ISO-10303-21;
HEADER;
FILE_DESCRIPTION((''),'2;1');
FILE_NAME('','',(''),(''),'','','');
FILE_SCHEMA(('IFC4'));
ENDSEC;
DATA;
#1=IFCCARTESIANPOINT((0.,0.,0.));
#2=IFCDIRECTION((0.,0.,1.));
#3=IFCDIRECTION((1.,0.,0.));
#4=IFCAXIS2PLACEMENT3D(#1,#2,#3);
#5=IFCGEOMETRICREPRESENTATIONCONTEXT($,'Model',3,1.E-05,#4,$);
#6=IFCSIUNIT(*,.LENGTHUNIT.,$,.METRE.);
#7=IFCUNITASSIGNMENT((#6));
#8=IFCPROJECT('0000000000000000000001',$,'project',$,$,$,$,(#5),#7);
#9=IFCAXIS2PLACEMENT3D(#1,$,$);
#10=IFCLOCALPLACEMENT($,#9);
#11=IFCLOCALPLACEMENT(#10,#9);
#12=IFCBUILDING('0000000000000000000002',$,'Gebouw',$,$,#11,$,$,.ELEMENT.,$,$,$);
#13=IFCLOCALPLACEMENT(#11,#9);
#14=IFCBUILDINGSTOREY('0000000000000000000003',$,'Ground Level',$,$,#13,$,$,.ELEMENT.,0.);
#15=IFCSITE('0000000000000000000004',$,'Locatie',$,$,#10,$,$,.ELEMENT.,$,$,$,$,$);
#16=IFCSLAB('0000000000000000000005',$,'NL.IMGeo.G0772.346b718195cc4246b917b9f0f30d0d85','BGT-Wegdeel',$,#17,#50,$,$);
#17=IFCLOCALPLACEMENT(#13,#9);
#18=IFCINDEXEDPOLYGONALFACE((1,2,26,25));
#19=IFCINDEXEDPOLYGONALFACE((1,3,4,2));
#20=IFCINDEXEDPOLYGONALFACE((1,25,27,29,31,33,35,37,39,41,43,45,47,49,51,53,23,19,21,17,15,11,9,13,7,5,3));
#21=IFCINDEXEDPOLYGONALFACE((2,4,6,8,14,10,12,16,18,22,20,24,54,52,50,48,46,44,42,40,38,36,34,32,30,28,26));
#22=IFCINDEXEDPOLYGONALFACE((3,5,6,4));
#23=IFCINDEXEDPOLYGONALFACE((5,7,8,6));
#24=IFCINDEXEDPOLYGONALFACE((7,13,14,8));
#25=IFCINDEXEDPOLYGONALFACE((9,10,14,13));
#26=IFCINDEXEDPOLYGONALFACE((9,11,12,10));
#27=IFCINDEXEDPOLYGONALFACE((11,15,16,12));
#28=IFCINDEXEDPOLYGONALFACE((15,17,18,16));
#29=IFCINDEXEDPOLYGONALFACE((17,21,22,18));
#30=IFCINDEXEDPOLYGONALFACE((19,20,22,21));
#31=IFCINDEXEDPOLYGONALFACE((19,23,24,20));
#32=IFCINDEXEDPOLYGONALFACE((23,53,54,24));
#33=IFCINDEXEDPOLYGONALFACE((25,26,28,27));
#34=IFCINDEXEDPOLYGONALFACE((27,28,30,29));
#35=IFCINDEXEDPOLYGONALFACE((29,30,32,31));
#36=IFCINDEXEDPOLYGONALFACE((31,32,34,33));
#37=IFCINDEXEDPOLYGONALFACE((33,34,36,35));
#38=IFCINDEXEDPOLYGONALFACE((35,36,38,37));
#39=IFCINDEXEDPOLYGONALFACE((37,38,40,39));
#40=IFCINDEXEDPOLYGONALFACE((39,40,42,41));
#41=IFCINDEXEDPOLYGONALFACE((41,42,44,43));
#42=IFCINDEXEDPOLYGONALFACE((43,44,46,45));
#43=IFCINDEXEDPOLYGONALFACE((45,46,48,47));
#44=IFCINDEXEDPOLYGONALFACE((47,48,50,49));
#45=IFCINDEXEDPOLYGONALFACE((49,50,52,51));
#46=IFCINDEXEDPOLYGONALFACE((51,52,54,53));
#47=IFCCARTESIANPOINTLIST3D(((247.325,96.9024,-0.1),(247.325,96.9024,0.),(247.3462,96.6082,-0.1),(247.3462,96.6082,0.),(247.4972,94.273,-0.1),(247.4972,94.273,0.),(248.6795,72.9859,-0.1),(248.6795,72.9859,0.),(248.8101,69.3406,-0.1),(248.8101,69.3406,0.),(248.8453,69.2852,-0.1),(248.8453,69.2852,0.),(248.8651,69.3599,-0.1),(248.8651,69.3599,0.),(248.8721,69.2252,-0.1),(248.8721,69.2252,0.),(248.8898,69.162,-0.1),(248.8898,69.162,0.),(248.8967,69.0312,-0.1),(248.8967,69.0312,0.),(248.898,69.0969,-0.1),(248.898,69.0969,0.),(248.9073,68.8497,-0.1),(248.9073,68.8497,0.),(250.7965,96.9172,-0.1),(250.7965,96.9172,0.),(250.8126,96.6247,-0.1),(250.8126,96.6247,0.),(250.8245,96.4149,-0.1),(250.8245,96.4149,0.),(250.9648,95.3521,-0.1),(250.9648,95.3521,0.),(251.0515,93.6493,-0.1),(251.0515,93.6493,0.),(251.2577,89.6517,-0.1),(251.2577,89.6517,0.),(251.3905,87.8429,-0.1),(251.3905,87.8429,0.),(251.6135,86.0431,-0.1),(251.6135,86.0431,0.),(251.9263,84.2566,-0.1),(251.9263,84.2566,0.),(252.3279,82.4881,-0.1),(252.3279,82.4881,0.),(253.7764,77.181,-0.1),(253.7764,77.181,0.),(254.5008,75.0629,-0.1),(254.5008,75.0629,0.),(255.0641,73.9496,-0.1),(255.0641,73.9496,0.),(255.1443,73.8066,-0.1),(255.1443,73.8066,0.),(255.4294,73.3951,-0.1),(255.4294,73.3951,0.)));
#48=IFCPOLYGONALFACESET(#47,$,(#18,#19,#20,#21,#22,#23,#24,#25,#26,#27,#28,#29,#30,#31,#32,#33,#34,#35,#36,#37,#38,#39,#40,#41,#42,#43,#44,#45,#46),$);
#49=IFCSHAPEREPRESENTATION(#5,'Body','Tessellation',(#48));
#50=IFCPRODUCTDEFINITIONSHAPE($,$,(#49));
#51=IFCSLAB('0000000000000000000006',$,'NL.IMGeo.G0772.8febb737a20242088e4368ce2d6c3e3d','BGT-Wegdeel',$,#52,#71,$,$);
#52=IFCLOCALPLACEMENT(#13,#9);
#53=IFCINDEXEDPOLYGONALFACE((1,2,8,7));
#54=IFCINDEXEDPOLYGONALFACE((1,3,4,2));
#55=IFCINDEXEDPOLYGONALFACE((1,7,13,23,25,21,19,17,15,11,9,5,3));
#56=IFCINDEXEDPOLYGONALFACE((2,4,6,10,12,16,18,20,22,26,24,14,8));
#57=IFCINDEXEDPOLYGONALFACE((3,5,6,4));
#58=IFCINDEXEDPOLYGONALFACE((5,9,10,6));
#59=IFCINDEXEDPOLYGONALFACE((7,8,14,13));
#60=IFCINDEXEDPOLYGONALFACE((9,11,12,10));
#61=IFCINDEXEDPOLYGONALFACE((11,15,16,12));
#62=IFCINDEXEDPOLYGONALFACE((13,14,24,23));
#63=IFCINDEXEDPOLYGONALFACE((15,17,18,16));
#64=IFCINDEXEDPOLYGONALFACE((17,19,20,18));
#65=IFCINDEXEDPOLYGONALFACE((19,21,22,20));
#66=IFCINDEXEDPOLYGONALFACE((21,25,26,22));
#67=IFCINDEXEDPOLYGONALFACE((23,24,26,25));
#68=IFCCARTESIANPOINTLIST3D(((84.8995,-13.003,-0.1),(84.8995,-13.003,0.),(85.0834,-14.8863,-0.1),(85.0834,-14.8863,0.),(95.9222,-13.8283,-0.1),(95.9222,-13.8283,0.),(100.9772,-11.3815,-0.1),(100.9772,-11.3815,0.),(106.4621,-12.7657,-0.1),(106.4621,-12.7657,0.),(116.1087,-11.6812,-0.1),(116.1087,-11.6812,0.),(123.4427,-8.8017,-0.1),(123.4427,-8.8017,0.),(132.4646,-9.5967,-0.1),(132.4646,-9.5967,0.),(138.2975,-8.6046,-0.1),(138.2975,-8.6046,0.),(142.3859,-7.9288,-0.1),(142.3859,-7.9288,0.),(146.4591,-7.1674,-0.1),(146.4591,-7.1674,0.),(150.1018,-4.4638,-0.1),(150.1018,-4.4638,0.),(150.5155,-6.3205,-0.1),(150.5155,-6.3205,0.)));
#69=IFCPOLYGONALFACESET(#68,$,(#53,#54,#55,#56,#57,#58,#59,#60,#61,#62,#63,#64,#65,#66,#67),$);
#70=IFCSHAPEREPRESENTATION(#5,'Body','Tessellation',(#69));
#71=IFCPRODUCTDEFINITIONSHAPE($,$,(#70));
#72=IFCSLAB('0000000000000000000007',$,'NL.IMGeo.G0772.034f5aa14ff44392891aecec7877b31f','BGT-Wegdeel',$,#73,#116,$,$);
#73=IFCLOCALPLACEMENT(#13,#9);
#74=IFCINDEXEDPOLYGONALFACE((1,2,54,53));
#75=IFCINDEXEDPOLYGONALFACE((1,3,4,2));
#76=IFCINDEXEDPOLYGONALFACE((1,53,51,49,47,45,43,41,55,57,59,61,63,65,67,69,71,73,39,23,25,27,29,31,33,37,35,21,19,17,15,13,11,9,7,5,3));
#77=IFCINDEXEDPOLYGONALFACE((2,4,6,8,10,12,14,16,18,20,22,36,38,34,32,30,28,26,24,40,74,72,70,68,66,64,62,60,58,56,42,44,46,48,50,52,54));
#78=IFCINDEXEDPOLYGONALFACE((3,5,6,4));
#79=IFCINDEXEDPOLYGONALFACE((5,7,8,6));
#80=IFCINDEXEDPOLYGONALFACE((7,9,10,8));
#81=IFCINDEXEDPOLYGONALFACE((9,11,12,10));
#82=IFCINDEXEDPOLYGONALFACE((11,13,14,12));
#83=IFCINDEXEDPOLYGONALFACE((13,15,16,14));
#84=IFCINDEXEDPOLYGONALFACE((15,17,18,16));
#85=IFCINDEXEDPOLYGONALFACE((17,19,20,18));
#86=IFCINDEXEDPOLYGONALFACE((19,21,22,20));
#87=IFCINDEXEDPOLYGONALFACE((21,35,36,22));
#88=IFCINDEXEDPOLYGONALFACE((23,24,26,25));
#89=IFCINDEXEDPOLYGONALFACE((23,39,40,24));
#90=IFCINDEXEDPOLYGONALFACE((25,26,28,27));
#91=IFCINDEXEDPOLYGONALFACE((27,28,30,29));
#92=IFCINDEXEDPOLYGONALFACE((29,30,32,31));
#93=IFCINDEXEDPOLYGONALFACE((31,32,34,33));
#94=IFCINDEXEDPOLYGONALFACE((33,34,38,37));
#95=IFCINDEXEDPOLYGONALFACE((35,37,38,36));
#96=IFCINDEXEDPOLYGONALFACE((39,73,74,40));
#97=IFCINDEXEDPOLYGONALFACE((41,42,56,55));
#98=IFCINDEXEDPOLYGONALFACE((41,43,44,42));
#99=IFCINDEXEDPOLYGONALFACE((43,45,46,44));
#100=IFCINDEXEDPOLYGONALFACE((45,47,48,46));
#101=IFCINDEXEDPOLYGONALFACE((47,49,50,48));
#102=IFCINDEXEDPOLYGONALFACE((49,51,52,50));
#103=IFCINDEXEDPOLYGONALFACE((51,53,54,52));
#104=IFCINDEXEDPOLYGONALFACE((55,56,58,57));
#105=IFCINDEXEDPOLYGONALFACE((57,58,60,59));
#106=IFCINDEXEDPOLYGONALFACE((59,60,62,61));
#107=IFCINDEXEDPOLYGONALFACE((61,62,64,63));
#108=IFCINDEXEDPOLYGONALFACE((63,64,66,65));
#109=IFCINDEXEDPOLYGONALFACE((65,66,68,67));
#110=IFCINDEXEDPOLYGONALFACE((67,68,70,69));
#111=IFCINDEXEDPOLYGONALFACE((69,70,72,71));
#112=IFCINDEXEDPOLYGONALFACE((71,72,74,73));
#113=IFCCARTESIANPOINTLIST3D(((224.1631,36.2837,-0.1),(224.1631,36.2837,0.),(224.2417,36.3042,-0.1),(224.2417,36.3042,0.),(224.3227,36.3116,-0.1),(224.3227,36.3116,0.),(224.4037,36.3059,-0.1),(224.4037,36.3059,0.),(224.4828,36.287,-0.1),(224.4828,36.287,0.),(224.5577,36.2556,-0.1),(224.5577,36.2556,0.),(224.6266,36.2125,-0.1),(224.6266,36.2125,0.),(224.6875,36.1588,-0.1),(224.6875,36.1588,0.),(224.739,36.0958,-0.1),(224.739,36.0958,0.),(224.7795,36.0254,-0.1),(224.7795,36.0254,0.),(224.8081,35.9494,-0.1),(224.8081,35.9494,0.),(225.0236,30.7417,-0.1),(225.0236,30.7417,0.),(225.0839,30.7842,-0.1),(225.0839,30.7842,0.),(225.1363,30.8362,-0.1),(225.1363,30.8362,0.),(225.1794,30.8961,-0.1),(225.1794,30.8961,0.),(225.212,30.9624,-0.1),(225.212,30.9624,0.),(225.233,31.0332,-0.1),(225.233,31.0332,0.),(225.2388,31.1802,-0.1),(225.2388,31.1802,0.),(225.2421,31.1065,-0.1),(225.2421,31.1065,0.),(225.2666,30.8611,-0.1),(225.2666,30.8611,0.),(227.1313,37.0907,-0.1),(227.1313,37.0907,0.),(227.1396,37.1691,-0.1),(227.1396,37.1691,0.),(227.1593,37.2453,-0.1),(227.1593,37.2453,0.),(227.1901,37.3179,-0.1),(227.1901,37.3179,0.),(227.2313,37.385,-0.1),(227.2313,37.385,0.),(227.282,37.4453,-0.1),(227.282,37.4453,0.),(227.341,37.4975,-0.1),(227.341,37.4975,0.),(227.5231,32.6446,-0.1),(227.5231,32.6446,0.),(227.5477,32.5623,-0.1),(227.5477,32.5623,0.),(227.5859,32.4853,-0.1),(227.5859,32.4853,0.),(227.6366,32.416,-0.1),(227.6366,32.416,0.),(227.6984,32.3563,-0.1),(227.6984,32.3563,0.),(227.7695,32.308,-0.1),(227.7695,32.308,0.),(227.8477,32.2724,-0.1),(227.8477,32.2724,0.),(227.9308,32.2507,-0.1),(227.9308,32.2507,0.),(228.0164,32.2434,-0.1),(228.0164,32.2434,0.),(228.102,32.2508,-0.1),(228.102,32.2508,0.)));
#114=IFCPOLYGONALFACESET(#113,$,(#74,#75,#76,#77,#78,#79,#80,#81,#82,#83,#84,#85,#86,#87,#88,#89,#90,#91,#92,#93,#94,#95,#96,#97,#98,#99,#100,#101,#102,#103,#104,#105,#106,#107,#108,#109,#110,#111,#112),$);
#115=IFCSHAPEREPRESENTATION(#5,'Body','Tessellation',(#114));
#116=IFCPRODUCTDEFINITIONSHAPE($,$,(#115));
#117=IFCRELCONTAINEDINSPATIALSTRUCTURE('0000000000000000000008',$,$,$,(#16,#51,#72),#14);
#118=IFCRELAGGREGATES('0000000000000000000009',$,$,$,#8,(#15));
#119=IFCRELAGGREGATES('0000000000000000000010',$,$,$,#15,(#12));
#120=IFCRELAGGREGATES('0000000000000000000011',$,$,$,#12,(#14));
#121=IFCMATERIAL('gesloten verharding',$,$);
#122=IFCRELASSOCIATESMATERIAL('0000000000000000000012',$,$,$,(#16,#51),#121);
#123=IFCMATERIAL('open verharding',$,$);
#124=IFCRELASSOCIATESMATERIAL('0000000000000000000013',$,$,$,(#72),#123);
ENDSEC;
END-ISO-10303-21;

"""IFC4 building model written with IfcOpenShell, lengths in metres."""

from ifc_helpers import new_model, si_unit, frame, origin, origin_with_axes, place, context, project, spatial, polyline, outline, extrude, material, element, save


model = new_model("IFC4")

# Units and contexts
model_context = context("Model", 3, precision=1e-05, world=origin_with_axes())
ifc_project = project(units=[si_unit("LENGTHUNIT", "METRE")], contexts=[model_context])

# Site, building, storey
site_placement = place(None, origin())
site = spatial("IfcSite", under=ifc_project, at=site_placement, Name="Locatie", CompositionType="ELEMENT")
building_placement = place(site_placement, origin())
building = spatial("IfcBuilding", under=site, at=building_placement, Name="Gebouw", CompositionType="ELEMENT")
storey_placement = place(building_placement, origin())
storey = spatial("IfcBuildingStorey", under=building, at=storey_placement, Name="Ground Level", CompositionType="ELEMENT", Elevation=0.0)

# Slabs
ifc_material_1 = material(Name="open verharding")
ifc_material_2 = material(Name="gesloten verharding")
slab_1_placement = place(storey_placement, origin())
element("IfcSlab", 1, at=slab_1_placement, inside=storey, material=ifc_material_2, Name="NL.IMGeo.G0772.346b718195cc4246b917b9f0f30d0d85", Description="BGT-Wegdeel", context=model_context, shape_type="SweptSolid", body=[
    extrude(outline(polyline([(251.3905, 87.8429), (251.6135, 86.0431), (251.9263, 84.2566), (252.3279, 82.4881), (253.7764, 77.181), (254.5008, 75.0629), (255.0641, 73.9496), (255.1443, 73.8066), (255.4294, 73.3951), (248.9073, 68.8497), (248.8967, 69.0312), (248.898, 69.0969), (248.8898, 69.162), (248.8721, 69.2252), (248.8453, 69.2852), (248.8101, 69.3406), (248.8651, 69.3599), (248.6795, 72.9859), (247.4972, 94.273), (247.3462, 96.6082), (247.325, 96.9024), (250.7965, 96.9172), (250.8126, 96.6247), (250.8245, 96.4149), (250.9648, 95.3521), (251.0515, 93.6493), (251.2577, 89.6517), (251.3905, 87.8429)])), frame((0.0, 0.0, -0.1), z_axis=(0.0, 0.0, 1.0), x_axis=(1.0, 0.0, 0.0)), (0.0, 0.0, 1.0), 0.1),
])
slab_2_placement = place(storey_placement, origin())
element("IfcSlab", 2, at=slab_2_placement, inside=storey, material=ifc_material_2, Name="NL.IMGeo.G0772.8febb737a20242088e4368ce2d6c3e3d", Description="BGT-Wegdeel", context=model_context, shape_type="SweptSolid", body=[
    extrude(outline(polyline([(123.4427, -8.8017), (150.1018, -4.4638), (150.5155, -6.3205), (146.4591, -7.1674), (142.3859, -7.9288), (138.2975, -8.6046), (132.4646, -9.5967), (116.1087, -11.6812), (106.4621, -12.7657), (95.9222, -13.8283), (85.0834, -14.8863), (84.8995, -13.003), (100.9772, -11.3815), (123.4427, -8.8017)])), frame((0.0, 0.0, -0.1), z_axis=(0.0, 0.0, 1.0), x_axis=(1.0, 0.0, 0.0)), (0.0, 0.0, 1.0), 0.1),
])
slab_3_placement = place(storey_placement, origin())
element("IfcSlab", 3, at=slab_3_placement, inside=storey, material=ifc_material_1, Name="NL.IMGeo.G0772.034f5aa14ff44392891aecec7877b31f", Description="BGT-Wegdeel", context=model_context, shape_type="SweptSolid", body=[
    extrude(outline(polyline([(227.282, 37.4453), (227.2313, 37.385), (227.1901, 37.3179), (227.1593, 37.2453), (227.1396, 37.1691), (227.1313, 37.0907), (227.5231, 32.6446), (227.5477, 32.5623), (227.5859, 32.4853), (227.6366, 32.416), (227.6984, 32.3563), (227.7695, 32.308), (227.8477, 32.2724), (227.9308, 32.2507), (228.0164, 32.2434), (228.102, 32.2508), (225.2666, 30.8611), (225.0236, 30.7417), (225.0839, 30.7842), (225.1363, 30.8362), (225.1794, 30.8961), (225.212, 30.9624), (225.233, 31.0332), (225.2421, 31.1065), (225.2388, 31.1802), (224.8081, 35.9494), (224.7795, 36.0254), (224.739, 36.0958), (224.6875, 36.1588), (224.6266, 36.2125), (224.5577, 36.2556), (224.4828, 36.287), (224.4037, 36.3059), (224.3227, 36.3116), (224.2417, 36.3042), (224.1631, 36.2837), (227.341, 37.4975), (227.282, 37.4453)])), frame((0.0, 0.0, -0.1), z_axis=(0.0, 0.0, 1.0), x_axis=(1.0, 0.0, 0.0)), (0.0, 0.0, 1.0), 0.1),
])

save(model, "model.ifc")
